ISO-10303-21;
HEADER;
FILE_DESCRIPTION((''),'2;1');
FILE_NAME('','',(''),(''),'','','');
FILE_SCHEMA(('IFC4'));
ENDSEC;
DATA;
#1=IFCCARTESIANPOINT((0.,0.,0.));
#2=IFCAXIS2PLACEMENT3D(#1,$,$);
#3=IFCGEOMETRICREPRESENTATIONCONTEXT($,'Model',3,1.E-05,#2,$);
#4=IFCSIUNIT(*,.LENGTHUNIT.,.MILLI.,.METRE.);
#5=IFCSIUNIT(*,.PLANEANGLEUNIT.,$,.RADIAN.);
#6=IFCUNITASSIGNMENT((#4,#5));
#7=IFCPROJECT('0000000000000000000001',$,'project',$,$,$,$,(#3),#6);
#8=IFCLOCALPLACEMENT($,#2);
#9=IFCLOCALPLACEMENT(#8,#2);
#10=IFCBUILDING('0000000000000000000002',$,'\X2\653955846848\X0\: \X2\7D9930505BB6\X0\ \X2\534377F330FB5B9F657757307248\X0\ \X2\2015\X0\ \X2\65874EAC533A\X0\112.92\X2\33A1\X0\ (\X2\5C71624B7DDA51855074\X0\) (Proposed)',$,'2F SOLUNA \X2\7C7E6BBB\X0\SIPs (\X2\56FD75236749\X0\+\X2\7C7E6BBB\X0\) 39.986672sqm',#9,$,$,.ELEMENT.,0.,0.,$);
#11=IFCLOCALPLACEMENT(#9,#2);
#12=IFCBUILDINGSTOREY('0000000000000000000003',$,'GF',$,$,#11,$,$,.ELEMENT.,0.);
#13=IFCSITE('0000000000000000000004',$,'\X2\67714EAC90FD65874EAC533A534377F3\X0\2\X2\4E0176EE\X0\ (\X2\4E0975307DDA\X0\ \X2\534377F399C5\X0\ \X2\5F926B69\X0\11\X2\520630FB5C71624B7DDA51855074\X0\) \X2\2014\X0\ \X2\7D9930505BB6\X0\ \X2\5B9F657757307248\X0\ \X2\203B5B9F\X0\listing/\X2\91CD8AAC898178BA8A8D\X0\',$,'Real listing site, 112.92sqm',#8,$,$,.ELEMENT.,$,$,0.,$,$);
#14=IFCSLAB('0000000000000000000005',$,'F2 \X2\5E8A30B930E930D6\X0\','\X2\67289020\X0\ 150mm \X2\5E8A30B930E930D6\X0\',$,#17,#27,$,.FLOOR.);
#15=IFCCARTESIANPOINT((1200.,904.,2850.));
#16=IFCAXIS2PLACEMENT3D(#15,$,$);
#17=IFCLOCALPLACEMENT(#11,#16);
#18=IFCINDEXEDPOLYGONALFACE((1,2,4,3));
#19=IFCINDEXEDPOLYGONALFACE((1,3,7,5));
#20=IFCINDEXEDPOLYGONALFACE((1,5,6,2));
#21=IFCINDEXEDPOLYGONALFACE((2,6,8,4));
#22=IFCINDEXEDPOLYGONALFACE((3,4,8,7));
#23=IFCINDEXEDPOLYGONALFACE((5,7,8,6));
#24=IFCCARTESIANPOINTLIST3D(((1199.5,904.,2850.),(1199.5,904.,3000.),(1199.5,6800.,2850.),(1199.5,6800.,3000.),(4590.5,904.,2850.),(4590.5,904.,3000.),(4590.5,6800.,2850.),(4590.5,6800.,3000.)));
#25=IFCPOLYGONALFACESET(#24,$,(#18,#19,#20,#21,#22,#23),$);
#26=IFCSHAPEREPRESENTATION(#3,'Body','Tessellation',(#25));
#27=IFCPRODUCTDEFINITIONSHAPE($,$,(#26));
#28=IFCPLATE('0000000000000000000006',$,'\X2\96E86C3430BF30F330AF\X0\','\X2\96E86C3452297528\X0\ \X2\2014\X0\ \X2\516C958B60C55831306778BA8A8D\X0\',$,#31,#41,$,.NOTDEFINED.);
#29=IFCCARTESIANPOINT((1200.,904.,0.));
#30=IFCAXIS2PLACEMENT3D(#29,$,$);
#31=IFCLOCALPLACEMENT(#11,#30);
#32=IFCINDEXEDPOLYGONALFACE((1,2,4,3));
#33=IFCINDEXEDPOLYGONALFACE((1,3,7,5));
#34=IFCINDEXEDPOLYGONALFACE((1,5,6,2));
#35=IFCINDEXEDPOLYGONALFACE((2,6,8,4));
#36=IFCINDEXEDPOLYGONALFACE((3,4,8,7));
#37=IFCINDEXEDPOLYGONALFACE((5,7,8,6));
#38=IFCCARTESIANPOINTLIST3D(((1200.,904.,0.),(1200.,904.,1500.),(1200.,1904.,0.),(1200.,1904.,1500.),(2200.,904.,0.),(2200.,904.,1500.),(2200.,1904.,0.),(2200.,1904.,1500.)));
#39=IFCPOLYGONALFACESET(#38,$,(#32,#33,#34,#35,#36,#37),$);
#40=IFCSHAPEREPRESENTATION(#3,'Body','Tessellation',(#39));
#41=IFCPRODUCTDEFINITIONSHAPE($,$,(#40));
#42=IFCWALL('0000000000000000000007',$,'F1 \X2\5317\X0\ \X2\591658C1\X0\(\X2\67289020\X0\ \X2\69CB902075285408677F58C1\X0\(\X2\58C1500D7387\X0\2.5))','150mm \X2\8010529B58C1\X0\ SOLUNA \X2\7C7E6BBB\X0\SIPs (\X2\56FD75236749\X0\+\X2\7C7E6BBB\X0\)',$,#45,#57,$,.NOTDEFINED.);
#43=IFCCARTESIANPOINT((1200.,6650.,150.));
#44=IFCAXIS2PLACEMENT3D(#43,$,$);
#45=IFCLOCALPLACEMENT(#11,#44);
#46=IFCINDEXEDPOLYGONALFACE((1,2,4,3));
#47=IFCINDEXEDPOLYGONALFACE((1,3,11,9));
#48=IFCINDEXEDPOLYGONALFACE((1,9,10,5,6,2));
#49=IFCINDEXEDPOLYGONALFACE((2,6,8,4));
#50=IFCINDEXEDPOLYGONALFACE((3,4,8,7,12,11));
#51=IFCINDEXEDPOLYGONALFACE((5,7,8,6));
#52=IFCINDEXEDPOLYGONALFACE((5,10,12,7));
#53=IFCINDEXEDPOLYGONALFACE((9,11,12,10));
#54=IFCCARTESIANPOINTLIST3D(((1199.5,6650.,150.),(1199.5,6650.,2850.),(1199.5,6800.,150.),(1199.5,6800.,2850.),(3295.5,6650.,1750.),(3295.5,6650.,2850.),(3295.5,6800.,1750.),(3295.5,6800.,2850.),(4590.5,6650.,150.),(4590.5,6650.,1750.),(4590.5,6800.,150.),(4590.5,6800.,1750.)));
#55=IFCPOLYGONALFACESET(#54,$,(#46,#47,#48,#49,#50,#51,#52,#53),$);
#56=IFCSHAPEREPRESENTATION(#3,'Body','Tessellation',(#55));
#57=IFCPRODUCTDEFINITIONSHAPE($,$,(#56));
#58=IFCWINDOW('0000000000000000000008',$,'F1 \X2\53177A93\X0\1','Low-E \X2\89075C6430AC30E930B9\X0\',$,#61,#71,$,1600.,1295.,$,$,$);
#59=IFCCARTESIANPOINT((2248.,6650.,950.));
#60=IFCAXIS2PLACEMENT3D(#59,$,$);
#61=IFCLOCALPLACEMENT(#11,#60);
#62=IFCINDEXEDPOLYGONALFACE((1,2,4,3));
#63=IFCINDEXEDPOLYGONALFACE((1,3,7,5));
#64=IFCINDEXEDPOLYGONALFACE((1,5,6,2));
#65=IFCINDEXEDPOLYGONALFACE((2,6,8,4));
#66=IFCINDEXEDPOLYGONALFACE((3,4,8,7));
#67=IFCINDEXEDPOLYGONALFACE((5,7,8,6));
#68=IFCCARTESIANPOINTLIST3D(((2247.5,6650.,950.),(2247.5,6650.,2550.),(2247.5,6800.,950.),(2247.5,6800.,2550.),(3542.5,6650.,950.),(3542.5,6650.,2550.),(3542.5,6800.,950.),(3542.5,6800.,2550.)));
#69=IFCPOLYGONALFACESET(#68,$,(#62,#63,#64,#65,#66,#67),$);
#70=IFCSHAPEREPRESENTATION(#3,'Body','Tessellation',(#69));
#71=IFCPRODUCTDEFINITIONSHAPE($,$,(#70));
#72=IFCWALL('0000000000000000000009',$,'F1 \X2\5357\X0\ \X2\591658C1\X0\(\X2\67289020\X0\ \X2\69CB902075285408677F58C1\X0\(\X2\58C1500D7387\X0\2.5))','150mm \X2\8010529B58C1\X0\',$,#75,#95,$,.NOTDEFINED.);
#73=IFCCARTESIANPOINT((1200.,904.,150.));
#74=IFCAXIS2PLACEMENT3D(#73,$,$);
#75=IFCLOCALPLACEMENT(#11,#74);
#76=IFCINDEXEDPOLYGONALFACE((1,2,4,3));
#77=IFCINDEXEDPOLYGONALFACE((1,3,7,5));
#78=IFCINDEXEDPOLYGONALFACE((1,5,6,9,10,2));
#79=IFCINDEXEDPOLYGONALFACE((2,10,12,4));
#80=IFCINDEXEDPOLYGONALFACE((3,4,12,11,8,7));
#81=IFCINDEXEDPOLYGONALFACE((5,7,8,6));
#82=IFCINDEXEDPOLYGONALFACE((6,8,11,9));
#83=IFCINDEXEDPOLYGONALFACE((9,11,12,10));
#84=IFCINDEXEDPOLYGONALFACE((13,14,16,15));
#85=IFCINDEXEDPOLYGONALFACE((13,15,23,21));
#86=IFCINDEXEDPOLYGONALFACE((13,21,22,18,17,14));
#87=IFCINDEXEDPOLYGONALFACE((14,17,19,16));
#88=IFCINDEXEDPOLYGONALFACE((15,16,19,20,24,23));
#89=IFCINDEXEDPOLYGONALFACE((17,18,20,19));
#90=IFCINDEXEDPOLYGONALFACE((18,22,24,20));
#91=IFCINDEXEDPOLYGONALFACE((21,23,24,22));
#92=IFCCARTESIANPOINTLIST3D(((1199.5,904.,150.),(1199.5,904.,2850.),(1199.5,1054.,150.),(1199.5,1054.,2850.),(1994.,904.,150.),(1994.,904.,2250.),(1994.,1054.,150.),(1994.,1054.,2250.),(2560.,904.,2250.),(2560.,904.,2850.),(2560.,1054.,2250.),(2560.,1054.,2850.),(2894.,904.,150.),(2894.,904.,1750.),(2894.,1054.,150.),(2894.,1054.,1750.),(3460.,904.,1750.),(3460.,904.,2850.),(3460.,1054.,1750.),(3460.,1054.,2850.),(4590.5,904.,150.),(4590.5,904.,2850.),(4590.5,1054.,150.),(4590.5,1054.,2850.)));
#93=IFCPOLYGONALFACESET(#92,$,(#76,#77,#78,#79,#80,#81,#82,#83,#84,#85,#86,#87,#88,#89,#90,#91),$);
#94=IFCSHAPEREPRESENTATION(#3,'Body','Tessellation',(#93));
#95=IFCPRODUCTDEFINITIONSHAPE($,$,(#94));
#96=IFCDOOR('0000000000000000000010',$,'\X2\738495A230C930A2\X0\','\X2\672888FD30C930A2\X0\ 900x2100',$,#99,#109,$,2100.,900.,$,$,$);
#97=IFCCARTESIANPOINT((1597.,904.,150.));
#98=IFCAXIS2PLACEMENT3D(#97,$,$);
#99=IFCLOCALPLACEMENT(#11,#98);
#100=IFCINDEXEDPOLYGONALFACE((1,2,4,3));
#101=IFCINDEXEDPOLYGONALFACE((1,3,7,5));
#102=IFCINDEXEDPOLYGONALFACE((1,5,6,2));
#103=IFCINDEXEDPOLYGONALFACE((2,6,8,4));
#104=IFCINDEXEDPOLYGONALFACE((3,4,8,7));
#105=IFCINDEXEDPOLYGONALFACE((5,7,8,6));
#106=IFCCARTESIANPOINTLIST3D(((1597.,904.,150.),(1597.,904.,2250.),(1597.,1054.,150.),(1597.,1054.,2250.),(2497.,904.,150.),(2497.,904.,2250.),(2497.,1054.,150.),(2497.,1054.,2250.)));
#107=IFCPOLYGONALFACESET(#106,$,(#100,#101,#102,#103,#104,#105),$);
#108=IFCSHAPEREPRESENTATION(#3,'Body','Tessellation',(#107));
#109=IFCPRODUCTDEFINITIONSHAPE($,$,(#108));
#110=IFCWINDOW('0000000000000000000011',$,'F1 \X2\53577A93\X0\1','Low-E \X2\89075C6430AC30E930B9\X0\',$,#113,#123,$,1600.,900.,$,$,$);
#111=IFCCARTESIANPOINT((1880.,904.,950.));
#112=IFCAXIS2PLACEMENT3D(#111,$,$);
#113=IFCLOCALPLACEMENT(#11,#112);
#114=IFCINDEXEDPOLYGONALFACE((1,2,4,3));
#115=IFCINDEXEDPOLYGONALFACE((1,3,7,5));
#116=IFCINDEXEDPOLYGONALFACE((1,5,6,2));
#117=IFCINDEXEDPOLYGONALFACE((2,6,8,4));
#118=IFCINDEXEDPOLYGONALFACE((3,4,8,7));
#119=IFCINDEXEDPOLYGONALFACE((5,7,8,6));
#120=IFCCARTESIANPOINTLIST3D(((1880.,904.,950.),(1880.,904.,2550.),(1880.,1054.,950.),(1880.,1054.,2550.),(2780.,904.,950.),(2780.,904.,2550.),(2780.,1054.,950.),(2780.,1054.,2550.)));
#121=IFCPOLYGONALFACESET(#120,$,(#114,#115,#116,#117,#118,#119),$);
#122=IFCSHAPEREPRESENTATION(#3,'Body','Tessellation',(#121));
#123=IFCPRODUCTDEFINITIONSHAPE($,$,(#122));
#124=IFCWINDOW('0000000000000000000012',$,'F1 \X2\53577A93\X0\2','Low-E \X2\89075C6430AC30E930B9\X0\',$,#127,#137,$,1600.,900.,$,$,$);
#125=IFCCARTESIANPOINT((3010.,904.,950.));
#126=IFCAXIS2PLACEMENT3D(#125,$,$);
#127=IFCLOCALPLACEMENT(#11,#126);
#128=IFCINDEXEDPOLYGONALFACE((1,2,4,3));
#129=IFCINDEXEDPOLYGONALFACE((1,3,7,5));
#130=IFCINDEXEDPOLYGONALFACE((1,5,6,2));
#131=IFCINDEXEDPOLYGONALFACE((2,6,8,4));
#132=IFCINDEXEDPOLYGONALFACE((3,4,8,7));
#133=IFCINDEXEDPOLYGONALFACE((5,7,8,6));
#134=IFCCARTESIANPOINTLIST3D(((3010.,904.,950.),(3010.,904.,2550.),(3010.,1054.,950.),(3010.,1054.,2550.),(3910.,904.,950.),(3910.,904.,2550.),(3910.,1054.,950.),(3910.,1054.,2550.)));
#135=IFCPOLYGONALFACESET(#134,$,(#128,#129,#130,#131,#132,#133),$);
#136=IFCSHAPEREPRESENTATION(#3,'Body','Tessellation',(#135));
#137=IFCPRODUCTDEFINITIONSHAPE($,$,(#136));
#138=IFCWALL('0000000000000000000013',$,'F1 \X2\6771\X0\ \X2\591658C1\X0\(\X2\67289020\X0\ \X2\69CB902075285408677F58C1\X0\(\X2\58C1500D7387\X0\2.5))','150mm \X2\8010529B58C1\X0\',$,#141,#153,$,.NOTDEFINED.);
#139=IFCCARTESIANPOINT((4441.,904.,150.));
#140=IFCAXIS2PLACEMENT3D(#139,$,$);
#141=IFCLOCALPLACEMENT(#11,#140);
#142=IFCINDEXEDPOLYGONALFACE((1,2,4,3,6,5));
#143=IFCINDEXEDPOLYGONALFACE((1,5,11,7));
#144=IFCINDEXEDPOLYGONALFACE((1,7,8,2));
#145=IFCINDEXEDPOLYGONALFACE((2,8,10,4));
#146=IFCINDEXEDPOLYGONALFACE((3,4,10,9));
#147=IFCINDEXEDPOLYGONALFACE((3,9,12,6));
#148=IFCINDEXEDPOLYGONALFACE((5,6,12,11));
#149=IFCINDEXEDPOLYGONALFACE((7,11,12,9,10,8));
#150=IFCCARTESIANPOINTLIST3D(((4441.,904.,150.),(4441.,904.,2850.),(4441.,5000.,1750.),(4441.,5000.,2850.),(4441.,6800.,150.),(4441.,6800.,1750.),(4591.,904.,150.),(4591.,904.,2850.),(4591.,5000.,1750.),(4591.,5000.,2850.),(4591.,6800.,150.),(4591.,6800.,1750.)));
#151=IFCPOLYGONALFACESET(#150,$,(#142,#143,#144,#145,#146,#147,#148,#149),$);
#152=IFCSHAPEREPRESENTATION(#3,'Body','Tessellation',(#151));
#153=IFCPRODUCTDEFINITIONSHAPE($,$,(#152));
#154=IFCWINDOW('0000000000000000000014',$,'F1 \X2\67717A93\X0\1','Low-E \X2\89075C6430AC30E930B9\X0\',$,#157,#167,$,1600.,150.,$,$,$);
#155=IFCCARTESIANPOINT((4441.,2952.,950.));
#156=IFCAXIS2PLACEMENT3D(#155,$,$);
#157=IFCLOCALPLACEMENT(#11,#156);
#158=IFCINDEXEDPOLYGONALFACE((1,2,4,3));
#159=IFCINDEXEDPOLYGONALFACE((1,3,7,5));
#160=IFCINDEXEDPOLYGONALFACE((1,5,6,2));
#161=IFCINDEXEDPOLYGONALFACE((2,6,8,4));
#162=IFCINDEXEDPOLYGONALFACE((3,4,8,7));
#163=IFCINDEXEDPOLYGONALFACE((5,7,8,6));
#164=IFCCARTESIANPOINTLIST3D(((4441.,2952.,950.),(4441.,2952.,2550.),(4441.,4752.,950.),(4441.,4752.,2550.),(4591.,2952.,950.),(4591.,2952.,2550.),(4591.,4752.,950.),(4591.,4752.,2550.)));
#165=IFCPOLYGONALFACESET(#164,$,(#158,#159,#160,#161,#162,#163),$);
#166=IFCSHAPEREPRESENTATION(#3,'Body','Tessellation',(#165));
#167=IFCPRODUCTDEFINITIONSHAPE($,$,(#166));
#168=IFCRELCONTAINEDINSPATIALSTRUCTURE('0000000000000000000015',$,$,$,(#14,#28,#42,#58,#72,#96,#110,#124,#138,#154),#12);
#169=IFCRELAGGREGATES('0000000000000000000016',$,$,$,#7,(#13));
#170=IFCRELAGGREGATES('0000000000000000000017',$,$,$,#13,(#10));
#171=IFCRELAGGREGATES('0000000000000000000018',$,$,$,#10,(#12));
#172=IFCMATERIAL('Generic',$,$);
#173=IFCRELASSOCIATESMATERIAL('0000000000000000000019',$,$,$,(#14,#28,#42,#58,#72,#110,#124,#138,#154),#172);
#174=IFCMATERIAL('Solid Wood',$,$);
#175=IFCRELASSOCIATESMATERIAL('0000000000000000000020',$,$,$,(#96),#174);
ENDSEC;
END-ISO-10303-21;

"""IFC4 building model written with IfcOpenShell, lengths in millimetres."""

from ifc_helpers import new_model, si_unit, frame, frame_2d, origin, place, context, project, spatial, rectangle, extrude, material, element, fill, save


model = new_model("IFC4")

# Units and contexts
model_context = context("Model", 3, precision=1e-05, world=origin())
ifc_project = project(units=[si_unit("LENGTHUNIT", "METRE", prefix="MILLI"), si_unit("PLANEANGLEUNIT", "RADIAN")], contexts=[model_context])

# Site, building, storey
site_placement = place(None, origin())
site = spatial("IfcSite", under=ifc_project, at=site_placement, Name="東京都文京区千石2丁目 (三田線 千石駅 徒歩11分・山手線内側) — 継ぐ家 実敷地版 ※実listing/重説要確認", ObjectType="Real listing site, 112.92sqm", CompositionType="ELEMENT", RefElevation=0.0)
building_placement = place(site_placement, origin())
building = spatial("IfcBuilding", under=site, at=building_placement, Name="改善案: 継ぐ家 千石・実敷地版 ― 文京区112.92㎡ (山手線内側) (Proposed)", ObjectType="2F SOLUNA 籾殻SIPs (国産杉+籾殻) 39.986672sqm", CompositionType="ELEMENT", ElevationOfRefHeight=0.0, ElevationOfTerrain=0.0)
storey_placement = place(building_placement, origin())
storey = spatial("IfcBuildingStorey", under=building, at=storey_placement, Name="GF", CompositionType="ELEMENT", Elevation=0.0)

# Slab
ifc_material_1 = material(Name="Generic")
slab_1_placement = place(storey_placement, frame((1200.0, 904.0, 2850.0)))
element("IfcSlab", 1, at=slab_1_placement, inside=storey, material=ifc_material_1, Name="F2 床スラブ", Description="木造 150mm 床スラブ", PredefinedType="FLOOR", context=model_context, shape_type="SweptSolid", body=[
    extrude(rectangle(XDim=3391.0, YDim=5896.0, at=frame_2d((1695.0, 2948.0))), frame((1200.0, 904.0, 2850.0)), (0.0, 0.0, 1.0), 150.0),
])

# Plate
plate_placement = place(storey_placement, frame((1200.0, 904.0, 0.0)))
element("IfcPlate", 2, at=plate_placement, inside=storey, material=ifc_material_1, Name="雨水タンク", Description="雨水利用 — 公開情報で確認", PredefinedType="NOTDEFINED", context=model_context, shape_type="SweptSolid", body=[
    extrude(rectangle(XDim=1000.0, YDim=1000.0, at=frame_2d((500.0, 500.0))), frame((1200.0, 904.0, 0.0)), (0.0, 0.0, 1.0), 1500.0),
])

# Wall, opening, window
wall_1_placement = place(storey_placement, frame((1200.0, 6650.0, 150.0)))
wall_1 = element("IfcWall", 3, at=wall_1_placement, inside=storey, material=ifc_material_1, Name="F1 北 外壁(木造 構造用合板壁(壁倍率2.5))", Description="150mm 耐力壁 SOLUNA 籾殻SIPs (国産杉+籾殻)", PredefinedType="NOTDEFINED", context=model_context, shape_type="SweptSolid", body=[
    extrude(rectangle(XDim=3391.0, YDim=150.0, at=frame_2d((1695.0, 75.0))), frame((1200.0, 6650.0, 150.0)), (0.0, 0.0, 1.0), 2700.0),
])
opening_1_placement = place(storey_placement, frame((2248.0, 6650.0, 950.0)))
opening_1 = element("IfcOpeningElement", 4, at=opening_1_placement, cuts=wall_1, PredefinedType="NOTDEFINED", context=model_context, shape_type="SweptSolid", body=[
    extrude(rectangle(XDim=1295.0, YDim=150.0, at=frame_2d((647.0, 75.0))), frame((2248.0, 6650.0, 950.0)), (0.0, 0.0, 1.0), 1600.0),
])
window_1_placement = place(storey_placement, frame((2248.0, 6650.0, 950.0)))
window_1 = element("IfcWindow", 5, at=window_1_placement, inside=storey, material=ifc_material_1, Name="F1 北窓1", Description="Low-E 複層ガラス", OverallHeight=1600.0, OverallWidth=1295.0, context=model_context, shape_type="SweptSolid", body=[
    extrude(rectangle(XDim=1295.0, YDim=150.0, at=frame_2d((647.0, 75.0))), frame((2248.0, 6650.0, 950.0)), (0.0, 0.0, 1.0), 1600.0),
])
fill(opening_1, window_1)

# Wall, openings, door, windows
wall_2_placement = place(storey_placement, frame((1200.0, 904.0, 150.0)))
wall_2 = element("IfcWall", 6, at=wall_2_placement, inside=storey, material=ifc_material_1, Name="F1 南 外壁(木造 構造用合板壁(壁倍率2.5))", Description="150mm 耐力壁", PredefinedType="NOTDEFINED", context=model_context, shape_type="SweptSolid", body=[
    extrude(rectangle(XDim=3391.0, YDim=150.0, at=frame_2d((1695.0, 75.0))), frame((1200.0, 904.0, 150.0)), (0.0, 0.0, 1.0), 2700.0),
])
opening_2_placement = place(storey_placement, frame((1597.0, 904.0, 150.0)))
opening_2 = element("IfcOpeningElement", 7, at=opening_2_placement, cuts=wall_2, PredefinedType="NOTDEFINED", context=model_context, shape_type="SweptSolid", body=[
    extrude(rectangle(XDim=900.0, YDim=150.0, at=frame_2d((450.0, 75.0))), frame((1597.0, 904.0, 150.0)), (0.0, 0.0, 1.0), 2100.0),
])
opening_3_placement = place(storey_placement, frame((1880.0, 904.0, 950.0)))
opening_3 = element("IfcOpeningElement", 8, at=opening_3_placement, cuts=wall_2, PredefinedType="NOTDEFINED", context=model_context, shape_type="SweptSolid", body=[
    extrude(rectangle(XDim=900.0, YDim=150.0, at=frame_2d((450.0, 75.0))), frame((1880.0, 904.0, 950.0)), (0.0, 0.0, 1.0), 1600.0),
])
opening_4_placement = place(storey_placement, frame((3010.0, 904.0, 950.0)))
opening_4 = element("IfcOpeningElement", 9, at=opening_4_placement, cuts=wall_2, PredefinedType="NOTDEFINED", context=model_context, shape_type="SweptSolid", body=[
    extrude(rectangle(XDim=900.0, YDim=150.0, at=frame_2d((450.0, 75.0))), frame((3010.0, 904.0, 950.0)), (0.0, 0.0, 1.0), 1600.0),
])
ifc_material_2 = material(Name="Solid Wood")
door_placement = place(storey_placement, frame((1597.0, 904.0, 150.0)))
door = element("IfcDoor", 10, at=door_placement, inside=storey, material=ifc_material_2, Name="玄関ドア", Description="木製ドア 900x2100", OverallHeight=2100.0, OverallWidth=900.0, context=model_context, shape_type="SweptSolid", body=[
    extrude(rectangle(XDim=900.0, YDim=150.0, at=frame_2d((450.0, 75.0))), frame((1597.0, 904.0, 150.0)), (0.0, 0.0, 1.0), 2100.0),
])
fill(opening_2, door)
window_2_placement = place(storey_placement, frame((1880.0, 904.0, 950.0)))
window_2 = element("IfcWindow", 11, at=window_2_placement, inside=storey, material=ifc_material_1, Name="F1 南窓1", Description="Low-E 複層ガラス", OverallHeight=1600.0, OverallWidth=900.0, context=model_context, shape_type="SweptSolid", body=[
    extrude(rectangle(XDim=900.0, YDim=150.0, at=frame_2d((450.0, 75.0))), frame((1880.0, 904.0, 950.0)), (0.0, 0.0, 1.0), 1600.0),
])
fill(opening_3, window_2)
window_3_placement = place(storey_placement, frame((3010.0, 904.0, 950.0)))
window_3 = element("IfcWindow", 12, at=window_3_placement, inside=storey, material=ifc_material_1, Name="F1 南窓2", Description="Low-E 複層ガラス", OverallHeight=1600.0, OverallWidth=900.0, context=model_context, shape_type="SweptSolid", body=[
    extrude(rectangle(XDim=900.0, YDim=150.0, at=frame_2d((450.0, 75.0))), frame((3010.0, 904.0, 950.0)), (0.0, 0.0, 1.0), 1600.0),
])
fill(opening_4, window_3)

# Wall, opening, window
wall_3_placement = place(storey_placement, frame((4441.0, 904.0, 150.0)))
wall_3 = element("IfcWall", 13, at=wall_3_placement, inside=storey, material=ifc_material_1, Name="F1 東 外壁(木造 構造用合板壁(壁倍率2.5))", Description="150mm 耐力壁", PredefinedType="NOTDEFINED", context=model_context, shape_type="SweptSolid", body=[
    extrude(rectangle(XDim=150.0, YDim=5896.0, at=frame_2d((75.0, 2948.0))), frame((4441.0, 904.0, 150.0)), (0.0, 0.0, 1.0), 2700.0),
])
opening_5_placement = place(storey_placement, frame((4441.0, 2952.0, 950.0)))
opening_5 = element("IfcOpeningElement", 14, at=opening_5_placement, cuts=wall_3, PredefinedType="NOTDEFINED", context=model_context, shape_type="SweptSolid", body=[
    extrude(rectangle(XDim=150.0, YDim=1800.0, at=frame_2d((75.0, 900.0))), frame((4441.0, 2952.0, 950.0)), (0.0, 0.0, 1.0), 1600.0),
])
window_4_placement = place(storey_placement, frame((4441.0, 2952.0, 950.0)))
window_4 = element("IfcWindow", 15, at=window_4_placement, inside=storey, material=ifc_material_1, Name="F1 東窓1", Description="Low-E 複層ガラス", OverallHeight=1600.0, OverallWidth=150.0, context=model_context, shape_type="SweptSolid", body=[
    extrude(rectangle(XDim=150.0, YDim=1800.0, at=frame_2d((75.0, 900.0))), frame((4441.0, 2952.0, 950.0)), (0.0, 0.0, 1.0), 1600.0),
])
fill(opening_5, window_4)

save(model, "model.ifc")
